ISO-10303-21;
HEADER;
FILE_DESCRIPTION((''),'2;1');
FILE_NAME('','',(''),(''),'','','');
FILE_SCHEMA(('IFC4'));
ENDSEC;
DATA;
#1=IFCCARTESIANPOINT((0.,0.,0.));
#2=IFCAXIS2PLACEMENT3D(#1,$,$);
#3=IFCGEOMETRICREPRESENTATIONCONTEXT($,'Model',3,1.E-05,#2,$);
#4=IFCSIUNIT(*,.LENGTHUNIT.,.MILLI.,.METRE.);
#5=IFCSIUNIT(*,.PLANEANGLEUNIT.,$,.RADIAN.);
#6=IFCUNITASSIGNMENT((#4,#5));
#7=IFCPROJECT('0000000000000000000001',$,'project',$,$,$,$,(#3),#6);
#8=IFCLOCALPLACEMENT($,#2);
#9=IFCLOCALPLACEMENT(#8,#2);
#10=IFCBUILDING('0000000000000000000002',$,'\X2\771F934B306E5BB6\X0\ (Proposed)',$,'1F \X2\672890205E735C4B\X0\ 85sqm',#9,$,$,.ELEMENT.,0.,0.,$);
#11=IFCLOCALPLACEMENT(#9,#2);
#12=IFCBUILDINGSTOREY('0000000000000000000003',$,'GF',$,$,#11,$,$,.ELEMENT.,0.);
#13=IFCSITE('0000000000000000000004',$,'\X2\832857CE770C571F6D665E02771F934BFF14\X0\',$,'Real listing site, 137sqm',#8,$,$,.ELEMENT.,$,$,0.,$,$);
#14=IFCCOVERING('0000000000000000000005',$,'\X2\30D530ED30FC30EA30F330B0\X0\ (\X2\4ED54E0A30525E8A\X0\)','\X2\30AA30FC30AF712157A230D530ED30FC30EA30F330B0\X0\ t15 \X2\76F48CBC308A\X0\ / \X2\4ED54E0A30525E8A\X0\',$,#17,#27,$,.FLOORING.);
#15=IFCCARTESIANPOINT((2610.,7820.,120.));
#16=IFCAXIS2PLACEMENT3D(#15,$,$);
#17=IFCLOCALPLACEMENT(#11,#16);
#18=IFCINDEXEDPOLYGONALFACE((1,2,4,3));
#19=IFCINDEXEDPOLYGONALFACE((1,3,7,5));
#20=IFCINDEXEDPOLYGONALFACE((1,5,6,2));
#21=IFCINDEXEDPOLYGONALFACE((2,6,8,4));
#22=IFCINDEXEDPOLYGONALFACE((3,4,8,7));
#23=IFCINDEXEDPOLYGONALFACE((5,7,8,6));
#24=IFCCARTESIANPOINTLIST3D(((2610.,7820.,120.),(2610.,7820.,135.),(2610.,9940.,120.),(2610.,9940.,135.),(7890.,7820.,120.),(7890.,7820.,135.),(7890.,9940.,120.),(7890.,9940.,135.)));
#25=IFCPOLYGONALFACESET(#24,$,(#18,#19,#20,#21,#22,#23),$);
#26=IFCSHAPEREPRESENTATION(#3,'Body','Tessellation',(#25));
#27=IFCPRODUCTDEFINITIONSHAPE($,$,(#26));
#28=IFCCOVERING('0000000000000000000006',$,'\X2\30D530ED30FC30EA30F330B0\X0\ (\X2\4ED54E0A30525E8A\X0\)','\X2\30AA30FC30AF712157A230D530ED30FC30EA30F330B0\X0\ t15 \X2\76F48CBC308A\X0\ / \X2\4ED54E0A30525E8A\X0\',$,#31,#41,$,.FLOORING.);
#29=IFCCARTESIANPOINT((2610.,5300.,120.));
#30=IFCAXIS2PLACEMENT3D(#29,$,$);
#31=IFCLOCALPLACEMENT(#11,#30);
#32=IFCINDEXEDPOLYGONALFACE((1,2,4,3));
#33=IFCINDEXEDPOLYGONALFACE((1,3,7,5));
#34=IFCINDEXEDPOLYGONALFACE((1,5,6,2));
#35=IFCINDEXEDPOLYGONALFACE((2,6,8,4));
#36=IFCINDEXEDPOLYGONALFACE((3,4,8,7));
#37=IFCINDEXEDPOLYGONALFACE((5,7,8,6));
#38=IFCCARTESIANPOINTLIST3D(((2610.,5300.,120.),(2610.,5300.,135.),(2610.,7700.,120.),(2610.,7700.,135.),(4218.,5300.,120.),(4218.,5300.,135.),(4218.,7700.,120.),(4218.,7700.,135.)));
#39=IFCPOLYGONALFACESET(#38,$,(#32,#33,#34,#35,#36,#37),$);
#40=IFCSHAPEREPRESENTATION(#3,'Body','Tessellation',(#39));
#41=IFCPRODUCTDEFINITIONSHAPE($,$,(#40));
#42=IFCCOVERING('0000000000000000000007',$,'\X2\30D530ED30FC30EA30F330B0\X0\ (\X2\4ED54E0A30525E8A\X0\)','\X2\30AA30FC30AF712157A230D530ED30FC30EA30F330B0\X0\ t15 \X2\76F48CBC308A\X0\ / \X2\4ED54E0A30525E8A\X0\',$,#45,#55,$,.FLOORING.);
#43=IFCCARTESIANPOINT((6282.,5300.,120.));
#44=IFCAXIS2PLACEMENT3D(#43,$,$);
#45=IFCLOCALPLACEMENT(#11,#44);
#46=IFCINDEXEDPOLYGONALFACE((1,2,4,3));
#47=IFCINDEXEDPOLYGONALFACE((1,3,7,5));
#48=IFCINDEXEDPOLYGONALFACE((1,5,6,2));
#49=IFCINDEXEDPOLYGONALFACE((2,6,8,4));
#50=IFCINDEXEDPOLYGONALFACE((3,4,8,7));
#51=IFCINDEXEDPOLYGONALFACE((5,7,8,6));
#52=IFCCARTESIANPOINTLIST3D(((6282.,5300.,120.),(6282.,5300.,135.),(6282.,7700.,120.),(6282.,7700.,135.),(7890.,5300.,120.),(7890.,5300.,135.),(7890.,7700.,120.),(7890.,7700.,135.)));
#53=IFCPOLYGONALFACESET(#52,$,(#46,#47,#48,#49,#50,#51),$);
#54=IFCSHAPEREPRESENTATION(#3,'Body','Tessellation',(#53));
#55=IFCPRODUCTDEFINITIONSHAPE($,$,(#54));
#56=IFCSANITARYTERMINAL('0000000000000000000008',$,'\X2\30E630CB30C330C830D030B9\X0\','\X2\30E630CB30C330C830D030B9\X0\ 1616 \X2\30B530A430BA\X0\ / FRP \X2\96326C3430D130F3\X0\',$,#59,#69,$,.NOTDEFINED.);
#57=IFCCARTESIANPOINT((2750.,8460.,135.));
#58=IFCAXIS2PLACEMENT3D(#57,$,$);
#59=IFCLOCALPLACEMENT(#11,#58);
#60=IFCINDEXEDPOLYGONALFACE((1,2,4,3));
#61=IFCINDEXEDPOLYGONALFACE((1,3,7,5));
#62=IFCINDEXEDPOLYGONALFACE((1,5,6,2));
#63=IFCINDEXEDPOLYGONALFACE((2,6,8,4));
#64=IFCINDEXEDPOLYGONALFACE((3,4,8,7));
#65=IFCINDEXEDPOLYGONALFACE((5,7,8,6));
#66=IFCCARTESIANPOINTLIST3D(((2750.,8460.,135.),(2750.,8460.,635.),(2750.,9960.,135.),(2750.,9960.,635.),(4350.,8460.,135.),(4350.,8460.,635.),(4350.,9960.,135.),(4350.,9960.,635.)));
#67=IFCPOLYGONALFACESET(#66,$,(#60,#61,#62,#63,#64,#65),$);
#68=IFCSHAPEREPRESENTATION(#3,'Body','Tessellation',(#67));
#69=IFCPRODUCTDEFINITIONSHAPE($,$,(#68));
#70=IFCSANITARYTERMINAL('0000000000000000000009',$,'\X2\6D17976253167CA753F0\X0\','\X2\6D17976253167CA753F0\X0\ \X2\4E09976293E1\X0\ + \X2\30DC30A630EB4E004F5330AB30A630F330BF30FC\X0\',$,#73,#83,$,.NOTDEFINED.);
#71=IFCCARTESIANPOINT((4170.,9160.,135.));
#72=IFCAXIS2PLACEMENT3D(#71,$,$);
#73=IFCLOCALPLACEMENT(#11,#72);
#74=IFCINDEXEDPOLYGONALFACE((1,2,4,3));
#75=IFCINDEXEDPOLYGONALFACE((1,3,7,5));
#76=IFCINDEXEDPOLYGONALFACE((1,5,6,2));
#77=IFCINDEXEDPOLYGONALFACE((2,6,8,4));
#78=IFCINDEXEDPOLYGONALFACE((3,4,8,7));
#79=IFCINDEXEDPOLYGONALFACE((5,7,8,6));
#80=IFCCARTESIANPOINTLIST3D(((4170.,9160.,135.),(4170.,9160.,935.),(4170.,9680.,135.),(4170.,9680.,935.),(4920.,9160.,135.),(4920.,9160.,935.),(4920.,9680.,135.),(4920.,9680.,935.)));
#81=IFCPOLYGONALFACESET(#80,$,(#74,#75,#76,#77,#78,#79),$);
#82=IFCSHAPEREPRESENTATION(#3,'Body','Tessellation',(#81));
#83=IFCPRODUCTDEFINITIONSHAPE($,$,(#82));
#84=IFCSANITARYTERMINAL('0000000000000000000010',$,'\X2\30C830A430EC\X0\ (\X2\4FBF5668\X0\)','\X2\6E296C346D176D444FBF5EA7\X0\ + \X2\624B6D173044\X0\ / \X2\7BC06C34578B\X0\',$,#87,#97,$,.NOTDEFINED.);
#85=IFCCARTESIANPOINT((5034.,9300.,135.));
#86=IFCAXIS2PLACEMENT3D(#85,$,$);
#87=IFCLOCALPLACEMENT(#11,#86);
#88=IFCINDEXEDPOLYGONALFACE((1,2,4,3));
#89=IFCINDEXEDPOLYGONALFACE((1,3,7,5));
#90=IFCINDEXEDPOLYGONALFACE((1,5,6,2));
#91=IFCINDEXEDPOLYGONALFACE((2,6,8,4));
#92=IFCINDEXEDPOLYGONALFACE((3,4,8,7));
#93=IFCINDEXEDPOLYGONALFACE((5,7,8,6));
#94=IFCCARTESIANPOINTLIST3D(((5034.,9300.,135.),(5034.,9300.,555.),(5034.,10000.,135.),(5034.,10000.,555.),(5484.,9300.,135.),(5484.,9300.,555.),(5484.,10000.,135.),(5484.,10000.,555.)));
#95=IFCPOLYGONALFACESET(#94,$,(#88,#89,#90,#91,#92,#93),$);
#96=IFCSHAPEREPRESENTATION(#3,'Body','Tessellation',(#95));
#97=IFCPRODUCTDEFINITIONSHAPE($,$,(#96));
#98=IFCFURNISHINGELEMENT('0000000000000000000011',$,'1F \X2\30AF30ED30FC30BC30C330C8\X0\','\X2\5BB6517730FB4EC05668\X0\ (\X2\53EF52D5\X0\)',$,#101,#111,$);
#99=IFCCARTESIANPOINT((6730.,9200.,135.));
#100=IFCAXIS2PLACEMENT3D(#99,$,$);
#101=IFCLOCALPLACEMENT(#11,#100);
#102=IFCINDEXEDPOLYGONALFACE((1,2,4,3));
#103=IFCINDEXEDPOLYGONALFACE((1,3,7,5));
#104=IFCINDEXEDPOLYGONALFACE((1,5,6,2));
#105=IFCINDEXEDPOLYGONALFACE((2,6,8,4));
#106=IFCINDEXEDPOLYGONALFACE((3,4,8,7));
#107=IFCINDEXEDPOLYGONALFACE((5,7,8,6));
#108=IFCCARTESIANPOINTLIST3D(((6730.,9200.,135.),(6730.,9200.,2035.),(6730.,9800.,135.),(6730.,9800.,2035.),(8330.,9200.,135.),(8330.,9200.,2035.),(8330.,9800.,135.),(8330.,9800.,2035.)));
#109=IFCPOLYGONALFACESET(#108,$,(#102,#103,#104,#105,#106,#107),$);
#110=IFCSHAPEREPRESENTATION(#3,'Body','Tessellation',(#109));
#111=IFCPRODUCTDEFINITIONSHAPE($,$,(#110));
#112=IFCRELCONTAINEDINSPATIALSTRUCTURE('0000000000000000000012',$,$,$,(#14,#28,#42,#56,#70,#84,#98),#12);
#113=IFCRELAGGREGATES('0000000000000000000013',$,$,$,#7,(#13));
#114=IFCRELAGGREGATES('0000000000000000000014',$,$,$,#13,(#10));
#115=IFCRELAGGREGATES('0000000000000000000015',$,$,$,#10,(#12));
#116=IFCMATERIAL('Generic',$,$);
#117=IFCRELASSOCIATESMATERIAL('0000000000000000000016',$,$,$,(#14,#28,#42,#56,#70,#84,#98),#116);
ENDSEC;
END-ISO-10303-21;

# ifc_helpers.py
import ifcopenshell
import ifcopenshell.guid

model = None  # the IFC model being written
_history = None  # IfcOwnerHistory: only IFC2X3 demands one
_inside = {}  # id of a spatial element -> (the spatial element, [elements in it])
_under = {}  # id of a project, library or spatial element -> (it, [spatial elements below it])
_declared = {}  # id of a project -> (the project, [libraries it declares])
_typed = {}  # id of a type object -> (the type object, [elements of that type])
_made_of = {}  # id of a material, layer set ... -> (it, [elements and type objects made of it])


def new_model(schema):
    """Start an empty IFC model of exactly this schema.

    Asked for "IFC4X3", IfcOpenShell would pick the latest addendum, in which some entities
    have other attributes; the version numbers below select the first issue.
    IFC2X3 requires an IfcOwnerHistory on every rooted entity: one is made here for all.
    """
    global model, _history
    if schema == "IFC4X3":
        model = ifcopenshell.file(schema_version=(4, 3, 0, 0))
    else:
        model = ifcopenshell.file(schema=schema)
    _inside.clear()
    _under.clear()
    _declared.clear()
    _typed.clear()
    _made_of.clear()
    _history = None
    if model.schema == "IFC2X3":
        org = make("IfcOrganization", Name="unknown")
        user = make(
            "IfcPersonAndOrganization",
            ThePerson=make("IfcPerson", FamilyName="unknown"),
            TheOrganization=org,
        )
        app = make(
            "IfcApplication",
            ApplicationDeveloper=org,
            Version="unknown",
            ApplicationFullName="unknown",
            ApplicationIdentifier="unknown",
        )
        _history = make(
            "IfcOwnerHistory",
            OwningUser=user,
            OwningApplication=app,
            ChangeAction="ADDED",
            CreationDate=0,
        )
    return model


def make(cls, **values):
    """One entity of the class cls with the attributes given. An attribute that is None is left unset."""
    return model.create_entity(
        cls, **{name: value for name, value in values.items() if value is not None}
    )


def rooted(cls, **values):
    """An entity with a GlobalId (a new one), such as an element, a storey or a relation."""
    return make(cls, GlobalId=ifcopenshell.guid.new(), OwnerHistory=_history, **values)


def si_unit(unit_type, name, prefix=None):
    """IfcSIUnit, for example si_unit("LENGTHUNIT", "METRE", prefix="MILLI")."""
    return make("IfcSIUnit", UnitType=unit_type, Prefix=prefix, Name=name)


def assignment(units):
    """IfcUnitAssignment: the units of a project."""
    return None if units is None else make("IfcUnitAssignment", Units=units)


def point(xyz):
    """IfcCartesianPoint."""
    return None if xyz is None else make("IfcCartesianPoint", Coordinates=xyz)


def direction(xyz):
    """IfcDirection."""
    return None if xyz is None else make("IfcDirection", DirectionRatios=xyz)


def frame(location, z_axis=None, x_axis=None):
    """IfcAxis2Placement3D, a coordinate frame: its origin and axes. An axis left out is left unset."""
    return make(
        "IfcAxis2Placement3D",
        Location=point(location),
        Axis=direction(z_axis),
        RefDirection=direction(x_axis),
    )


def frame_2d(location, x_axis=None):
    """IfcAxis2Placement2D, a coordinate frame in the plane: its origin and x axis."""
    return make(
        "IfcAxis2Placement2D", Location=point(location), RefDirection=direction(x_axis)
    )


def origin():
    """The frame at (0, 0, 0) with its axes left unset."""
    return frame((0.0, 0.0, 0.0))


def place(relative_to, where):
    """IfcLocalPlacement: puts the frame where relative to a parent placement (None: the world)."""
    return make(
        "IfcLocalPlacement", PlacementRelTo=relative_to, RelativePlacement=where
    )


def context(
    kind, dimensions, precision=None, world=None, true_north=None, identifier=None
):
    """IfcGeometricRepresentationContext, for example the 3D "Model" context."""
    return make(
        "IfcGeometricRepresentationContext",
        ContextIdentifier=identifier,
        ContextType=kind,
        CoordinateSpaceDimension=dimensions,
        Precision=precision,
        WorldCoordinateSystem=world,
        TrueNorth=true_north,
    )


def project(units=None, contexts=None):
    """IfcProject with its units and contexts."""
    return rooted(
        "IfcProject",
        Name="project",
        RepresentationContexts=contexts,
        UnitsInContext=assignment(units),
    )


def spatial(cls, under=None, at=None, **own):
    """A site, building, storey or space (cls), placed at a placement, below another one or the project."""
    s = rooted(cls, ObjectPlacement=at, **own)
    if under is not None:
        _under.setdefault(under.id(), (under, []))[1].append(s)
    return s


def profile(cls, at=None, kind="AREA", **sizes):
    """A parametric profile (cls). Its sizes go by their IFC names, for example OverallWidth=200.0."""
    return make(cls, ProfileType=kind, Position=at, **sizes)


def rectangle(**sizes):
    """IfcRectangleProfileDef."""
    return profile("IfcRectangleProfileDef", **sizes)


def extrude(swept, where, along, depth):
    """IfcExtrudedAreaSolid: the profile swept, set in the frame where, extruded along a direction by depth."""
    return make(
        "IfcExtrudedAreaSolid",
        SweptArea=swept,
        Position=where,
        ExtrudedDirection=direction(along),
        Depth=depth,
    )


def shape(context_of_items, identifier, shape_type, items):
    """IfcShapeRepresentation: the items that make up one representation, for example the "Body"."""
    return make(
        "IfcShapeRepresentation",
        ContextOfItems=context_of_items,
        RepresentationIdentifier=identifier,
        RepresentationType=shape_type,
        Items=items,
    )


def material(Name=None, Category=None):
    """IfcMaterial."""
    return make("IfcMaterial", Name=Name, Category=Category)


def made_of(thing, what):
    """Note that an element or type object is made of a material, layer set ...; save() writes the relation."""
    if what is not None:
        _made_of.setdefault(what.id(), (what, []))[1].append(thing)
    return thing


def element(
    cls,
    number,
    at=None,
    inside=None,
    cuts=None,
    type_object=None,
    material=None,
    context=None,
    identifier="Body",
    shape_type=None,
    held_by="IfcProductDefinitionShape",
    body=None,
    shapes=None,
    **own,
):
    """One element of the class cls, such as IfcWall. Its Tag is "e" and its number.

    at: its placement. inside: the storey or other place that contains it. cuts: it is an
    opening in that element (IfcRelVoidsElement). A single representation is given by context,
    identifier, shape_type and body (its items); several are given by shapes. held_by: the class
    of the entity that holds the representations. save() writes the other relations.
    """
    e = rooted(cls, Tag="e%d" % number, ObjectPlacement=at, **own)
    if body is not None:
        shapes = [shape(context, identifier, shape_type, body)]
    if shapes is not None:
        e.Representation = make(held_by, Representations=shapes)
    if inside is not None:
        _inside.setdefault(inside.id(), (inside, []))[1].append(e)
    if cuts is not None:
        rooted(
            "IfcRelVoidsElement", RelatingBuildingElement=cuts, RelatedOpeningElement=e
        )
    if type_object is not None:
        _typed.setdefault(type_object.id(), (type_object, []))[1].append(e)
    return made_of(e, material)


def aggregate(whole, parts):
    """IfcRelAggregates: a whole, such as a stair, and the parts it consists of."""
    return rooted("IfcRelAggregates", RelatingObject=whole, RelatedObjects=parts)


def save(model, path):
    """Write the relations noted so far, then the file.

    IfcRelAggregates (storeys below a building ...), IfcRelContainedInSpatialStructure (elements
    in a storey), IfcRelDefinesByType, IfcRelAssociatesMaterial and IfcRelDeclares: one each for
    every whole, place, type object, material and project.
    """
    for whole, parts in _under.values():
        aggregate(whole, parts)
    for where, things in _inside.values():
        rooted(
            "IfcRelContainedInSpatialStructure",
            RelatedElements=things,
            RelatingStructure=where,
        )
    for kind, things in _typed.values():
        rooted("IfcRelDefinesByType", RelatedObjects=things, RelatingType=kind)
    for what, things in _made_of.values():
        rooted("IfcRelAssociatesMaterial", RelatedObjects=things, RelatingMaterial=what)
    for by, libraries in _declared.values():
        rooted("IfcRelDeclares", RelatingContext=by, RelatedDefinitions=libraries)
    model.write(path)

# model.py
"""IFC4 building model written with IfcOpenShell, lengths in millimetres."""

from ifc_helpers import new_model, si_unit, frame, frame_2d, origin, place, context, project, spatial, rectangle, extrude, material, element, save


model = new_model("IFC4")

# Units and contexts
model_context = context("Model", 3, precision=1e-05, world=origin())
ifc_project = project(units=[si_unit("LENGTHUNIT", "METRE", prefix="MILLI"), si_unit("PLANEANGLEUNIT", "RADIAN")], contexts=[model_context])

# Site, building, storey
site_placement = place(None, origin())
site = spatial("IfcSite", under=ifc_project, at=site_placement, Name="茨城県土浦市真鍋４", ObjectType="Real listing site, 137sqm", CompositionType="ELEMENT", RefElevation=0.0)
building_placement = place(site_placement, origin())
building = spatial("IfcBuilding", under=site, at=building_placement, Name="真鍋の家 (Proposed)", ObjectType="1F 木造平屋 85sqm", CompositionType="ELEMENT", ElevationOfRefHeight=0.0, ElevationOfTerrain=0.0)
storey_placement = place(building_placement, origin())
storey = spatial("IfcBuildingStorey", under=building, at=storey_placement, Name="GF", CompositionType="ELEMENT", Elevation=0.0)

# Coverings
ifc_material_1 = material(Name="Generic")
covering_1_placement = place(storey_placement, frame((2610.0, 7820.0, 120.0)))
element("IfcCovering", 1, at=covering_1_placement, inside=storey, material=ifc_material_1, Name="フローリング (仕上げ床)", Description="オーク無垢フローリング t15 直貼り / 仕上げ床", PredefinedType="FLOORING", context=model_context, shape_type="SweptSolid", body=[
    extrude(rectangle(XDim=5280.0, YDim=2120.0, at=frame_2d((2640.0, 1060.0))), frame((2610.0, 7820.0, 120.0)), (0.0, 0.0, 1.0), 15.0),
])
covering_2_placement = place(storey_placement, frame((2610.0, 5300.0, 120.0)))
element("IfcCovering", 2, at=covering_2_placement, inside=storey, material=ifc_material_1, Name="フローリング (仕上げ床)", Description="オーク無垢フローリング t15 直貼り / 仕上げ床", PredefinedType="FLOORING", context=model_context, shape_type="SweptSolid", body=[
    extrude(rectangle(XDim=1608.0, YDim=2400.0, at=frame_2d((804.0, 1200.0))), frame((2610.0, 5300.0, 120.0)), (0.0, 0.0, 1.0), 15.0),
])
covering_3_placement = place(storey_placement, frame((6282.0, 5300.0, 120.0)))
element("IfcCovering", 3, at=covering_3_placement, inside=storey, material=ifc_material_1, Name="フローリング (仕上げ床)", Description="オーク無垢フローリング t15 直貼り / 仕上げ床", PredefinedType="FLOORING", context=model_context, shape_type="SweptSolid", body=[
    extrude(rectangle(XDim=1608.0, YDim=2400.0, at=frame_2d((804.0, 1200.0))), frame((6282.0, 5300.0, 120.0)), (0.0, 0.0, 1.0), 15.0),
])

# Sanitary terminals
sanitary_terminal_1_placement = place(storey_placement, frame((2750.0, 8460.0, 135.0)))
element("IfcSanitaryTerminal", 4, at=sanitary_terminal_1_placement, inside=storey, material=ifc_material_1, Name="ユニットバス", Description="ユニットバス 1616 サイズ / FRP 防水パン", PredefinedType="NOTDEFINED", context=model_context, shape_type="SweptSolid", body=[
    extrude(rectangle(XDim=1600.0, YDim=1500.0, at=frame_2d((800.0, 750.0))), frame((2750.0, 8460.0, 135.0)), (0.0, 0.0, 1.0), 500.0),
])
sanitary_terminal_2_placement = place(storey_placement, frame((4170.0, 9160.0, 135.0)))
element("IfcSanitaryTerminal", 5, at=sanitary_terminal_2_placement, inside=storey, material=ifc_material_1, Name="洗面化粧台", Description="洗面化粧台 三面鏡 + ボウル一体カウンター", PredefinedType="NOTDEFINED", context=model_context, shape_type="SweptSolid", body=[
    extrude(rectangle(XDim=750.0, YDim=520.0, at=frame_2d((375.0, 260.0))), frame((4170.0, 9160.0, 135.0)), (0.0, 0.0, 1.0), 800.0),
])
sanitary_terminal_3_placement = place(storey_placement, frame((5034.0, 9300.0, 135.0)))
element("IfcSanitaryTerminal", 6, at=sanitary_terminal_3_placement, inside=storey, material=ifc_material_1, Name="トイレ (便器)", Description="温水洗浄便座 + 手洗い / 節水型", PredefinedType="NOTDEFINED", context=model_context, shape_type="SweptSolid", body=[
    extrude(rectangle(XDim=450.0, YDim=700.0, at=frame_2d((225.0, 350.0))), frame((5034.0, 9300.0, 135.0)), (0.0, 0.0, 1.0), 420.0),
])

# Furnishing element
furnishing_placement = place(storey_placement, frame((6730.0, 9200.0, 135.0)))
element("IfcFurnishingElement", 7, at=furnishing_placement, inside=storey, material=ifc_material_1, Name="1F クローゼット", Description="家具・什器 (可動)", context=model_context, shape_type="SweptSolid", body=[
    extrude(rectangle(XDim=1600.0, YDim=600.0, at=frame_2d((800.0, 300.0))), frame((6730.0, 9200.0, 135.0)), (0.0, 0.0, 1.0), 1900.0),
])

save(model, "model.ifc")
